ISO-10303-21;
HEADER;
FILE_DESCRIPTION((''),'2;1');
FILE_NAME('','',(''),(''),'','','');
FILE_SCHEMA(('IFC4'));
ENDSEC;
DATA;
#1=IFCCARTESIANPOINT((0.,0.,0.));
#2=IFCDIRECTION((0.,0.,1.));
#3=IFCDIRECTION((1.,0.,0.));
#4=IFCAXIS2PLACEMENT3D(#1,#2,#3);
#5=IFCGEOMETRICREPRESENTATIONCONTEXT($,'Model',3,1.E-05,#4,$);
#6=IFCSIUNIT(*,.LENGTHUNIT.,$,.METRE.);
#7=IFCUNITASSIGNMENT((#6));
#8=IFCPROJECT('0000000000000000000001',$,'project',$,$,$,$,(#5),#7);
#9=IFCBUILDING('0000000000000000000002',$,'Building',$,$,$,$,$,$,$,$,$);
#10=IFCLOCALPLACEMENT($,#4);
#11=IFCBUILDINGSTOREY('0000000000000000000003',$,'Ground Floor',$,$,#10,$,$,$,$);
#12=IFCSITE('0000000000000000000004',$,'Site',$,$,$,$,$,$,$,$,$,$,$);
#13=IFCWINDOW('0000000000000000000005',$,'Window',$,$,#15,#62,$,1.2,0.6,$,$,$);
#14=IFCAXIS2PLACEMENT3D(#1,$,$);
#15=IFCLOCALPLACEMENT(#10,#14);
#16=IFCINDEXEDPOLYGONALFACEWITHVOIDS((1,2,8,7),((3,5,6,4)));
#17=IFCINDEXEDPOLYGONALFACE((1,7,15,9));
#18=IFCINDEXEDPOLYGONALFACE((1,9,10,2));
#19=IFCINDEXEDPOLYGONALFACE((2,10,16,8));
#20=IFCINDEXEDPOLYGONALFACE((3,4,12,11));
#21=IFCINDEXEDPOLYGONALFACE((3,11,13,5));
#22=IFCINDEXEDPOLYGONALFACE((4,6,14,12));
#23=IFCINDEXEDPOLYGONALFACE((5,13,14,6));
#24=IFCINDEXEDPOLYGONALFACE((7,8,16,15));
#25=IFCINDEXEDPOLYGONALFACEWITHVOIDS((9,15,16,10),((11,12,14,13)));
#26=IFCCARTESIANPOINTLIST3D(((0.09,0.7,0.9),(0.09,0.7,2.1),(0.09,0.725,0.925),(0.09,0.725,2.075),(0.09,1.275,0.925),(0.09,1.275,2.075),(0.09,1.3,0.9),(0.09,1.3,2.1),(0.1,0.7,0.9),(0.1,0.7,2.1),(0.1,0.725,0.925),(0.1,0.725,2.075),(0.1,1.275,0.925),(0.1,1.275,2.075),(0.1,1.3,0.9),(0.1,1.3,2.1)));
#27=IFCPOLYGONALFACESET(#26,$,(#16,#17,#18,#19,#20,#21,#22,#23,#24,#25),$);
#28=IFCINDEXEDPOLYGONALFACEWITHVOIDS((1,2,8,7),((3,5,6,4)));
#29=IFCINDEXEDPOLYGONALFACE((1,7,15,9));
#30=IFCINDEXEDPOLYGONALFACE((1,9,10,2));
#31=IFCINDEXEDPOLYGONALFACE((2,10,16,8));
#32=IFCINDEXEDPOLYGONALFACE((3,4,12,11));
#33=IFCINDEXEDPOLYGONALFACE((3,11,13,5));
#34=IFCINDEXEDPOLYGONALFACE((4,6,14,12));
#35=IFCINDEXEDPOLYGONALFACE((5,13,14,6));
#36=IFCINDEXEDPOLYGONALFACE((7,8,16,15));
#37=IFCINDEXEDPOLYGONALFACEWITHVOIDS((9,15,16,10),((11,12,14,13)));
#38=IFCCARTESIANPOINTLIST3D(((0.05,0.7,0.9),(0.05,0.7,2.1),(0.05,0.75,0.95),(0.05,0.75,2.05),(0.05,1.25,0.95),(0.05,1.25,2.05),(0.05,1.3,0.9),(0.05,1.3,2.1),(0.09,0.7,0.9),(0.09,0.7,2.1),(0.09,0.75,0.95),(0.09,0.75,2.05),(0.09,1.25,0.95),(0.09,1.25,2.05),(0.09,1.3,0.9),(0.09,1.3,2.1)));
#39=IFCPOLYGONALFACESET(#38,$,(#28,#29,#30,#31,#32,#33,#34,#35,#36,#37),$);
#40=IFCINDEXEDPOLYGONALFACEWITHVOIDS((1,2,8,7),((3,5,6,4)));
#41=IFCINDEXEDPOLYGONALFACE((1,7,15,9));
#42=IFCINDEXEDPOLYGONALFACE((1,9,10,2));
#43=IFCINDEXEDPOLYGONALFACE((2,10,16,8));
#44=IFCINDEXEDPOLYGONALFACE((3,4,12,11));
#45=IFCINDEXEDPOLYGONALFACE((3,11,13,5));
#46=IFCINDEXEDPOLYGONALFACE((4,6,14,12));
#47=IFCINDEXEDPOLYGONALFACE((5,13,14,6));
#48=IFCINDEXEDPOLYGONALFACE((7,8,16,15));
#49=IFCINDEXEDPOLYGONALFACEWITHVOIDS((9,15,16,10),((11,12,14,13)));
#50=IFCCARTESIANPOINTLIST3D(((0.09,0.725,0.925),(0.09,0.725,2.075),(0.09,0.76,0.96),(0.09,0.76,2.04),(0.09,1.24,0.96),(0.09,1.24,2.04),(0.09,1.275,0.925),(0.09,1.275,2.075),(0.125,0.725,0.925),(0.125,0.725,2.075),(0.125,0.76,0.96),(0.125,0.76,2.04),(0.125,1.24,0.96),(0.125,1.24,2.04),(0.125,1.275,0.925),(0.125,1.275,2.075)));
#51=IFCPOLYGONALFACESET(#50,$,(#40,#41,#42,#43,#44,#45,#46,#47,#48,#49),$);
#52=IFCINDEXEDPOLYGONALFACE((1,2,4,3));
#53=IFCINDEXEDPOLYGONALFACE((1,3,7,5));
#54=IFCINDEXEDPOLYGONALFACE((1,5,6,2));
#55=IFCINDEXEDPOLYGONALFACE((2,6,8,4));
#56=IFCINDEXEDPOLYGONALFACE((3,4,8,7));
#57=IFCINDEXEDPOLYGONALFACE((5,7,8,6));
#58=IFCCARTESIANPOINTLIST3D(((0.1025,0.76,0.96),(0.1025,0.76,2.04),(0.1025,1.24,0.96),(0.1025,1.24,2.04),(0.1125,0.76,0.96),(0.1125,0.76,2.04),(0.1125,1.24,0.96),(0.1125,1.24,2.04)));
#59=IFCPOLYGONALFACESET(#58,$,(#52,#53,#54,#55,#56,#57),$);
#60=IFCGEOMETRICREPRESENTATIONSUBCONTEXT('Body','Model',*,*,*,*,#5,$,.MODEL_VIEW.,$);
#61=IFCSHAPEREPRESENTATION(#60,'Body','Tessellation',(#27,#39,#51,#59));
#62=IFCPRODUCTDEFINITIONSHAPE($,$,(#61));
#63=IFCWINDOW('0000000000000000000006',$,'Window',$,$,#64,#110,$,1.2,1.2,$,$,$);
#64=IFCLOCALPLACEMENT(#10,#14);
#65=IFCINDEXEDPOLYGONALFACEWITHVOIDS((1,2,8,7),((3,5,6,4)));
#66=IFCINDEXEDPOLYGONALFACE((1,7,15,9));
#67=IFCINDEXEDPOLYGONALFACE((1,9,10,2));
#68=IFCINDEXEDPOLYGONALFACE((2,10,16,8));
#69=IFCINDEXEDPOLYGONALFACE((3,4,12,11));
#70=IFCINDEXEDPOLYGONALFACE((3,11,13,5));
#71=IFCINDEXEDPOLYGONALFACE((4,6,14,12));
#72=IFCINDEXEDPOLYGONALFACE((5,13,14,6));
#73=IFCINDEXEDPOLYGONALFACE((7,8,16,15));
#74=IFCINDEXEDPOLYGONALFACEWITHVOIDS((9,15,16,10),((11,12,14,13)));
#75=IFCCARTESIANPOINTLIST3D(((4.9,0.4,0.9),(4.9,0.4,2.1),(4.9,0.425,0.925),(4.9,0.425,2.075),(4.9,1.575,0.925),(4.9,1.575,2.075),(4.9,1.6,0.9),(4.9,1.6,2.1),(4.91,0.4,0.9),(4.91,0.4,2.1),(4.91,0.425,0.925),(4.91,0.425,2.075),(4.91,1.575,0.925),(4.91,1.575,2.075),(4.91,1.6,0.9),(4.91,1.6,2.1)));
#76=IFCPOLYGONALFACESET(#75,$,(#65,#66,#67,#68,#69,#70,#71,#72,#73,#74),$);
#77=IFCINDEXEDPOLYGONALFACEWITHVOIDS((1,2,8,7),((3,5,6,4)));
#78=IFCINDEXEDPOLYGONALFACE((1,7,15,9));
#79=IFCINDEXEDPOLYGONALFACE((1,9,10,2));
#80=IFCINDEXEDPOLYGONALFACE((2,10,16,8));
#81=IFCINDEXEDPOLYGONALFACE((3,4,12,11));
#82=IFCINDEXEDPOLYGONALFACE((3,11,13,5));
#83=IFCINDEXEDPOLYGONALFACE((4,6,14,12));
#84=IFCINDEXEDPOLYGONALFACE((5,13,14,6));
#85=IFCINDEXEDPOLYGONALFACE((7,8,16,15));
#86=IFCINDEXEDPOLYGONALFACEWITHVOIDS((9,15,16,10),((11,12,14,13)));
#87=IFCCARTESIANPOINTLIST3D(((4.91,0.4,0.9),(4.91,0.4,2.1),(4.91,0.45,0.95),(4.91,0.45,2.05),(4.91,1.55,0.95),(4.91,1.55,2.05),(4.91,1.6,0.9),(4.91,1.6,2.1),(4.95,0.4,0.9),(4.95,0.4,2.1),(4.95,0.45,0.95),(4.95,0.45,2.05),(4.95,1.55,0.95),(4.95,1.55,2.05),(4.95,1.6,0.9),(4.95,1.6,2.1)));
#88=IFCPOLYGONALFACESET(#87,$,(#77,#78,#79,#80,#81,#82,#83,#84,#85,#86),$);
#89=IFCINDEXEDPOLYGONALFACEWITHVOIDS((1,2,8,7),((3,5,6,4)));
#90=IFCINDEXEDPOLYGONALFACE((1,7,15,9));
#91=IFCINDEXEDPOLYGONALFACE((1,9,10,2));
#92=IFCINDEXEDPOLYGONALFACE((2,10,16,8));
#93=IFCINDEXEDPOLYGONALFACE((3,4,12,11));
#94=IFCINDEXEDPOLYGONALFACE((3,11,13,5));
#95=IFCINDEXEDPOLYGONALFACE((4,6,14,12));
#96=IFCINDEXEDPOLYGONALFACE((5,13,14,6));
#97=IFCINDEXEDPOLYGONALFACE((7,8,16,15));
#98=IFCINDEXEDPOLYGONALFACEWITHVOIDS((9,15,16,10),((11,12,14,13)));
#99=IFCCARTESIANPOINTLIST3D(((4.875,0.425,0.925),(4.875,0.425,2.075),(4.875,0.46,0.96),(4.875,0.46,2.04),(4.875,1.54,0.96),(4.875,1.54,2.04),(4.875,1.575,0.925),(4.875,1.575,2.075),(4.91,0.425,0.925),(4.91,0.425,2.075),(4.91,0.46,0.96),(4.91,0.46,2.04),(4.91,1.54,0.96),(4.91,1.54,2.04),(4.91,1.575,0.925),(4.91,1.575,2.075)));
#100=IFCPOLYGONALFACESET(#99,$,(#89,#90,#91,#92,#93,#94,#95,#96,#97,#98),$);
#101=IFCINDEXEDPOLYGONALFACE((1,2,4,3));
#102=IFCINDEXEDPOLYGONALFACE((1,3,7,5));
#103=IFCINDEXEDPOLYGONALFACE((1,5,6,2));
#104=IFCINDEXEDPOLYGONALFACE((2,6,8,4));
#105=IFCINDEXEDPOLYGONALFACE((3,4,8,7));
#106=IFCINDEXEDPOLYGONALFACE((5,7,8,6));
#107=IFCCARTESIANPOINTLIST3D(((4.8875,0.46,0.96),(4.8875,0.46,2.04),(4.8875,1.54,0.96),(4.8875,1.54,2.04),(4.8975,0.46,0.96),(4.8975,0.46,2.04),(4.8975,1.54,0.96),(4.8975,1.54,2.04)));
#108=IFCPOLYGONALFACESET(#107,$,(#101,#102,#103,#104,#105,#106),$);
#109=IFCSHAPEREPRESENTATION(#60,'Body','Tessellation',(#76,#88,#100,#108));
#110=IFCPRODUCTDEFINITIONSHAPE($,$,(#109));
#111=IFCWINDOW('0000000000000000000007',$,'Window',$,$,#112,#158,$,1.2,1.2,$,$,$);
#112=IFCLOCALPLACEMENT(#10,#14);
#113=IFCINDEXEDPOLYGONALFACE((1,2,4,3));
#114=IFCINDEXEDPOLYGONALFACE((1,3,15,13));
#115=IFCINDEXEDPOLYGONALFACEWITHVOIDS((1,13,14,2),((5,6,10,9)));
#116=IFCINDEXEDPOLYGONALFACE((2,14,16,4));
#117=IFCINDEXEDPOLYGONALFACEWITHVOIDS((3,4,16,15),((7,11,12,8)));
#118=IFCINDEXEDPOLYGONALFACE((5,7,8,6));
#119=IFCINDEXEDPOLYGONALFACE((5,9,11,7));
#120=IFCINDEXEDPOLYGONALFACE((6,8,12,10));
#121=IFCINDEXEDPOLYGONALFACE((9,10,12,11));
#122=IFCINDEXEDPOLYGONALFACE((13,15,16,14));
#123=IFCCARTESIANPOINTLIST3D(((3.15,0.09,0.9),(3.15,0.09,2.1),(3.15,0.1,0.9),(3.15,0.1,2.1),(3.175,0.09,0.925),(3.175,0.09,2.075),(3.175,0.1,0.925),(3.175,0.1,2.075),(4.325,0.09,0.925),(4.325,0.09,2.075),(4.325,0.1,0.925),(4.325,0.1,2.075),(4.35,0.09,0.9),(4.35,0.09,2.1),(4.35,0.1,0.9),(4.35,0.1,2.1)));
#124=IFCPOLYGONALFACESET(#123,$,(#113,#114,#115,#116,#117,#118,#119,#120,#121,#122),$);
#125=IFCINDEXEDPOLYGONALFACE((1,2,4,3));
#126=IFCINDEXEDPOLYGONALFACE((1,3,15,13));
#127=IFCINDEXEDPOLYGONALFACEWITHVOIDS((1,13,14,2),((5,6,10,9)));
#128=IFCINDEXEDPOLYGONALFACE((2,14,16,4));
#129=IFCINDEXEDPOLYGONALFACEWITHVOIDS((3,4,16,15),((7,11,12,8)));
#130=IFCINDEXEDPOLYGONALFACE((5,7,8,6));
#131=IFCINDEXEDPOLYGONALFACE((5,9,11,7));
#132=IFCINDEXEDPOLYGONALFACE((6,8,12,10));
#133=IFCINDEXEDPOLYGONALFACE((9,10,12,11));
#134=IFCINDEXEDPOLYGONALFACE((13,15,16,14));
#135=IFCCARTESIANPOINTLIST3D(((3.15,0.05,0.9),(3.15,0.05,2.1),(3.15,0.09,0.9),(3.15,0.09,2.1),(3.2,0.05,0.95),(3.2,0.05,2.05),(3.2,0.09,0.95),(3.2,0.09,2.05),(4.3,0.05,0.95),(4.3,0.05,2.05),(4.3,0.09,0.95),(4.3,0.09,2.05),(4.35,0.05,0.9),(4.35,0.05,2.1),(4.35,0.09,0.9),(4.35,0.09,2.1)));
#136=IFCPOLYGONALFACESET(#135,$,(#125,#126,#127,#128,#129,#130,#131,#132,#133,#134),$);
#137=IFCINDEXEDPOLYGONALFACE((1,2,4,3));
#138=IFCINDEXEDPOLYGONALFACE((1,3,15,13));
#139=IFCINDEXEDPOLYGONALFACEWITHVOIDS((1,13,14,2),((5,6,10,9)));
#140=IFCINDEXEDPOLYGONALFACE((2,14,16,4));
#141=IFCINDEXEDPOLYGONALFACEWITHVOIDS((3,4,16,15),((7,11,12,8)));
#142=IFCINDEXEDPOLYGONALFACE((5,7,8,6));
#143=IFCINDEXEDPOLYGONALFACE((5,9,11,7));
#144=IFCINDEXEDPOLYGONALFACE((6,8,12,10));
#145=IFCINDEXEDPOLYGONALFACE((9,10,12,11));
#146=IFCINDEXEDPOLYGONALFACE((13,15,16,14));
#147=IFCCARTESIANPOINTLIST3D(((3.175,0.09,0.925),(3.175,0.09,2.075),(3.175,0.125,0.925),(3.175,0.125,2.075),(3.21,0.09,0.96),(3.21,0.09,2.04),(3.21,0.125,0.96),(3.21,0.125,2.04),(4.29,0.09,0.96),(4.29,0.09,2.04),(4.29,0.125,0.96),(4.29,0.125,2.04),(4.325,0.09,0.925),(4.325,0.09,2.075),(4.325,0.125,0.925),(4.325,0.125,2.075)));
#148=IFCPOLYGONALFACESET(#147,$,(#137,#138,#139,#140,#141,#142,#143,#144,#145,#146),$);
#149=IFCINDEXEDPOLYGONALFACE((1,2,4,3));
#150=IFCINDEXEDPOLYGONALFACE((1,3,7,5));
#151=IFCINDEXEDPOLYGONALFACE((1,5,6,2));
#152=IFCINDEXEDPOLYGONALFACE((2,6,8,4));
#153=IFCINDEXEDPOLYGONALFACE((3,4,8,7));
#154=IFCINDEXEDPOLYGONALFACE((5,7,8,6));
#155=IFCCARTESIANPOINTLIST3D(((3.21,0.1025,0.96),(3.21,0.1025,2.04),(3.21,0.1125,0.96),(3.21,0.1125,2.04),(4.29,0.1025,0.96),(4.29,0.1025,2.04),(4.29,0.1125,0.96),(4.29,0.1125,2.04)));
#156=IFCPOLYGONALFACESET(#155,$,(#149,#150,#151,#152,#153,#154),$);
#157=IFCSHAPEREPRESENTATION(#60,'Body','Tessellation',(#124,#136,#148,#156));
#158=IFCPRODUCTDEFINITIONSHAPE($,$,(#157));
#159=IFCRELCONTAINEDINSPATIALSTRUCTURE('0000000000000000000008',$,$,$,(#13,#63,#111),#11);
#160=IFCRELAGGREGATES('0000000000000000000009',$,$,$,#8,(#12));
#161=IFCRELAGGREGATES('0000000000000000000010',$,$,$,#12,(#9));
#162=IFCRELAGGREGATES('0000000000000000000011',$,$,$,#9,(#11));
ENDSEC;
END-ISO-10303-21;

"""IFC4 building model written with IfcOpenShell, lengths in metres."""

from ifc_helpers import new_model, si_unit, frame, origin_with_axes, place, context, subcontext, project, spatial, line, indexed_curve, outline, extrude, element, save


model = new_model("IFC4")

# Units and contexts
model_context = context("Model", 3, precision=1e-05, world=origin_with_axes())
body_context = subcontext(model_context, "Body", "Model", "MODEL_VIEW")
ifc_project = project(units=[si_unit("LENGTHUNIT", "METRE")], contexts=[model_context])

# Site, building, storey
site = spatial("IfcSite", under=ifc_project, Name="Site")
building = spatial("IfcBuilding", under=site, Name="Building")
storey_placement = place(None, origin_with_axes())
storey = spatial("IfcBuildingStorey", under=building, at=storey_placement, Name="Ground Floor")

# Windows
window_placement = place(storey_placement, frame((0.0, 1.3, 0.9), z_axis=(0.0, 0.0, 1.0), x_axis=(0.0, -1.0, 0.0)))
element("IfcWindow", 1, at=window_placement, inside=storey, Name="Window", OverallHeight=1.2, OverallWidth=0.6, context=body_context, shape_type="SweptSolid", body=[
    extrude(outline(indexed_curve([(0.0, 0.0), (0.6, 0.0), (0.6, 1.2), (0.0, 1.2)], segments=[line(1, 2, 3, 4, 1)]), holes=[indexed_curve([(0.025, 0.025), (0.575, 0.025), (0.575, 1.175), (0.025, 1.175)], segments=[line(1, 2, 3, 4, 1)])]), frame((0.0, 0.09, 0.0), z_axis=(0.0, -1.0, 0.0), x_axis=(1.0, 0.0, 0.0)), (0.0, 0.0, -1.0), 0.01),
    extrude(outline(indexed_curve([(0.0, 0.0), (0.6, 0.0), (0.6, 1.2), (0.0, 1.2)], segments=[line(1, 2, 3, 4, 1)]), holes=[indexed_curve([(0.05, 0.05), (0.55, 0.05), (0.55, 1.15), (0.05, 1.15)], segments=[line(1, 2, 3, 4, 1)])]), frame((0.0, 0.05, 0.0), z_axis=(0.0, -1.0, 0.0), x_axis=(1.0, 0.0, 0.0)), (0.0, 0.0, -1.0), 0.04),
    extrude(outline(indexed_curve([(0.0, 0.0), (0.55, 0.0), (0.55, 1.15), (0.0, 1.15)], segments=[line(1, 2, 3, 4, 1)]), holes=[indexed_curve([(0.035, 0.035), (0.515, 0.035), (0.515, 1.115), (0.035, 1.115)], segments=[line(1, 2, 3, 4, 1)])]), frame((0.025, 0.09, 0.025), z_axis=(0.0, -1.0, 0.0), x_axis=(1.0, 0.0, 0.0)), (0.0, 0.0, -1.0), 0.035),
    extrude(outline(indexed_curve([(0.035, 0.035), (0.515, 0.035), (0.515, 1.115), (0.035, 1.115)], segments=[line(1, 2, 3, 4, 1)])), frame((0.025, 0.1025, 0.025), z_axis=(0.0, -1.0, 0.0), x_axis=(1.0, 0.0, 0.0)), (0.0, 0.0, -1.0), 0.01),
])
for number, where, z_axis, x_axis, name in (
    (2, (5.0, 0.4, 0.9), (0.0, 0.0, 1.0), (0.0, 1.0, 0.0), "Window"),
    (3, (3.15, 0.0, 0.9), (0.0, 0.0, 1.0), (1.0, 0.0, 0.0), "Window"),
):
    element("IfcWindow", number, at=place(storey_placement, frame(where, z_axis=z_axis, x_axis=x_axis)), inside=storey, Name=name, OverallHeight=1.2, OverallWidth=1.2, context=body_context, shape_type="SweptSolid", body=[
        extrude(outline(indexed_curve([(0.0, 0.0), (1.2, 0.0), (1.2, 1.2), (0.0, 1.2)], segments=[line(1, 2, 3, 4, 1)]), holes=[indexed_curve([(0.025, 0.025), (1.175, 0.025), (1.175, 1.175), (0.025, 1.175)], segments=[line(1, 2, 3, 4, 1)])]), frame((0.0, 0.09, 0.0), z_axis=(0.0, -1.0, 0.0), x_axis=(1.0, 0.0, 0.0)), (0.0, 0.0, -1.0), 0.01),
        extrude(outline(indexed_curve([(0.0, 0.0), (1.2, 0.0), (1.2, 1.2), (0.0, 1.2)], segments=[line(1, 2, 3, 4, 1)]), holes=[indexed_curve([(0.05, 0.05), (1.15, 0.05), (1.15, 1.15), (0.05, 1.15)], segments=[line(1, 2, 3, 4, 1)])]), frame((0.0, 0.05, 0.0), z_axis=(0.0, -1.0, 0.0), x_axis=(1.0, 0.0, 0.0)), (0.0, 0.0, -1.0), 0.04),
        extrude(outline(indexed_curve([(0.0, 0.0), (1.15, 0.0), (1.15, 1.15), (0.0, 1.15)], segments=[line(1, 2, 3, 4, 1)]), holes=[indexed_curve([(0.035, 0.035), (1.115, 0.035), (1.115, 1.115), (0.035, 1.115)], segments=[line(1, 2, 3, 4, 1)])]), frame((0.025, 0.09, 0.025), z_axis=(0.0, -1.0, 0.0), x_axis=(1.0, 0.0, 0.0)), (0.0, 0.0, -1.0), 0.035),
        extrude(outline(indexed_curve([(0.035, 0.035), (1.115, 0.035), (1.115, 1.115), (0.035, 1.115)], segments=[line(1, 2, 3, 4, 1)])), frame((0.025, 0.1025, 0.025), z_axis=(0.0, -1.0, 0.0), x_axis=(1.0, 0.0, 0.0)), (0.0, 0.0, -1.0), 0.01),
    ])

save(model, "model.ifc")
